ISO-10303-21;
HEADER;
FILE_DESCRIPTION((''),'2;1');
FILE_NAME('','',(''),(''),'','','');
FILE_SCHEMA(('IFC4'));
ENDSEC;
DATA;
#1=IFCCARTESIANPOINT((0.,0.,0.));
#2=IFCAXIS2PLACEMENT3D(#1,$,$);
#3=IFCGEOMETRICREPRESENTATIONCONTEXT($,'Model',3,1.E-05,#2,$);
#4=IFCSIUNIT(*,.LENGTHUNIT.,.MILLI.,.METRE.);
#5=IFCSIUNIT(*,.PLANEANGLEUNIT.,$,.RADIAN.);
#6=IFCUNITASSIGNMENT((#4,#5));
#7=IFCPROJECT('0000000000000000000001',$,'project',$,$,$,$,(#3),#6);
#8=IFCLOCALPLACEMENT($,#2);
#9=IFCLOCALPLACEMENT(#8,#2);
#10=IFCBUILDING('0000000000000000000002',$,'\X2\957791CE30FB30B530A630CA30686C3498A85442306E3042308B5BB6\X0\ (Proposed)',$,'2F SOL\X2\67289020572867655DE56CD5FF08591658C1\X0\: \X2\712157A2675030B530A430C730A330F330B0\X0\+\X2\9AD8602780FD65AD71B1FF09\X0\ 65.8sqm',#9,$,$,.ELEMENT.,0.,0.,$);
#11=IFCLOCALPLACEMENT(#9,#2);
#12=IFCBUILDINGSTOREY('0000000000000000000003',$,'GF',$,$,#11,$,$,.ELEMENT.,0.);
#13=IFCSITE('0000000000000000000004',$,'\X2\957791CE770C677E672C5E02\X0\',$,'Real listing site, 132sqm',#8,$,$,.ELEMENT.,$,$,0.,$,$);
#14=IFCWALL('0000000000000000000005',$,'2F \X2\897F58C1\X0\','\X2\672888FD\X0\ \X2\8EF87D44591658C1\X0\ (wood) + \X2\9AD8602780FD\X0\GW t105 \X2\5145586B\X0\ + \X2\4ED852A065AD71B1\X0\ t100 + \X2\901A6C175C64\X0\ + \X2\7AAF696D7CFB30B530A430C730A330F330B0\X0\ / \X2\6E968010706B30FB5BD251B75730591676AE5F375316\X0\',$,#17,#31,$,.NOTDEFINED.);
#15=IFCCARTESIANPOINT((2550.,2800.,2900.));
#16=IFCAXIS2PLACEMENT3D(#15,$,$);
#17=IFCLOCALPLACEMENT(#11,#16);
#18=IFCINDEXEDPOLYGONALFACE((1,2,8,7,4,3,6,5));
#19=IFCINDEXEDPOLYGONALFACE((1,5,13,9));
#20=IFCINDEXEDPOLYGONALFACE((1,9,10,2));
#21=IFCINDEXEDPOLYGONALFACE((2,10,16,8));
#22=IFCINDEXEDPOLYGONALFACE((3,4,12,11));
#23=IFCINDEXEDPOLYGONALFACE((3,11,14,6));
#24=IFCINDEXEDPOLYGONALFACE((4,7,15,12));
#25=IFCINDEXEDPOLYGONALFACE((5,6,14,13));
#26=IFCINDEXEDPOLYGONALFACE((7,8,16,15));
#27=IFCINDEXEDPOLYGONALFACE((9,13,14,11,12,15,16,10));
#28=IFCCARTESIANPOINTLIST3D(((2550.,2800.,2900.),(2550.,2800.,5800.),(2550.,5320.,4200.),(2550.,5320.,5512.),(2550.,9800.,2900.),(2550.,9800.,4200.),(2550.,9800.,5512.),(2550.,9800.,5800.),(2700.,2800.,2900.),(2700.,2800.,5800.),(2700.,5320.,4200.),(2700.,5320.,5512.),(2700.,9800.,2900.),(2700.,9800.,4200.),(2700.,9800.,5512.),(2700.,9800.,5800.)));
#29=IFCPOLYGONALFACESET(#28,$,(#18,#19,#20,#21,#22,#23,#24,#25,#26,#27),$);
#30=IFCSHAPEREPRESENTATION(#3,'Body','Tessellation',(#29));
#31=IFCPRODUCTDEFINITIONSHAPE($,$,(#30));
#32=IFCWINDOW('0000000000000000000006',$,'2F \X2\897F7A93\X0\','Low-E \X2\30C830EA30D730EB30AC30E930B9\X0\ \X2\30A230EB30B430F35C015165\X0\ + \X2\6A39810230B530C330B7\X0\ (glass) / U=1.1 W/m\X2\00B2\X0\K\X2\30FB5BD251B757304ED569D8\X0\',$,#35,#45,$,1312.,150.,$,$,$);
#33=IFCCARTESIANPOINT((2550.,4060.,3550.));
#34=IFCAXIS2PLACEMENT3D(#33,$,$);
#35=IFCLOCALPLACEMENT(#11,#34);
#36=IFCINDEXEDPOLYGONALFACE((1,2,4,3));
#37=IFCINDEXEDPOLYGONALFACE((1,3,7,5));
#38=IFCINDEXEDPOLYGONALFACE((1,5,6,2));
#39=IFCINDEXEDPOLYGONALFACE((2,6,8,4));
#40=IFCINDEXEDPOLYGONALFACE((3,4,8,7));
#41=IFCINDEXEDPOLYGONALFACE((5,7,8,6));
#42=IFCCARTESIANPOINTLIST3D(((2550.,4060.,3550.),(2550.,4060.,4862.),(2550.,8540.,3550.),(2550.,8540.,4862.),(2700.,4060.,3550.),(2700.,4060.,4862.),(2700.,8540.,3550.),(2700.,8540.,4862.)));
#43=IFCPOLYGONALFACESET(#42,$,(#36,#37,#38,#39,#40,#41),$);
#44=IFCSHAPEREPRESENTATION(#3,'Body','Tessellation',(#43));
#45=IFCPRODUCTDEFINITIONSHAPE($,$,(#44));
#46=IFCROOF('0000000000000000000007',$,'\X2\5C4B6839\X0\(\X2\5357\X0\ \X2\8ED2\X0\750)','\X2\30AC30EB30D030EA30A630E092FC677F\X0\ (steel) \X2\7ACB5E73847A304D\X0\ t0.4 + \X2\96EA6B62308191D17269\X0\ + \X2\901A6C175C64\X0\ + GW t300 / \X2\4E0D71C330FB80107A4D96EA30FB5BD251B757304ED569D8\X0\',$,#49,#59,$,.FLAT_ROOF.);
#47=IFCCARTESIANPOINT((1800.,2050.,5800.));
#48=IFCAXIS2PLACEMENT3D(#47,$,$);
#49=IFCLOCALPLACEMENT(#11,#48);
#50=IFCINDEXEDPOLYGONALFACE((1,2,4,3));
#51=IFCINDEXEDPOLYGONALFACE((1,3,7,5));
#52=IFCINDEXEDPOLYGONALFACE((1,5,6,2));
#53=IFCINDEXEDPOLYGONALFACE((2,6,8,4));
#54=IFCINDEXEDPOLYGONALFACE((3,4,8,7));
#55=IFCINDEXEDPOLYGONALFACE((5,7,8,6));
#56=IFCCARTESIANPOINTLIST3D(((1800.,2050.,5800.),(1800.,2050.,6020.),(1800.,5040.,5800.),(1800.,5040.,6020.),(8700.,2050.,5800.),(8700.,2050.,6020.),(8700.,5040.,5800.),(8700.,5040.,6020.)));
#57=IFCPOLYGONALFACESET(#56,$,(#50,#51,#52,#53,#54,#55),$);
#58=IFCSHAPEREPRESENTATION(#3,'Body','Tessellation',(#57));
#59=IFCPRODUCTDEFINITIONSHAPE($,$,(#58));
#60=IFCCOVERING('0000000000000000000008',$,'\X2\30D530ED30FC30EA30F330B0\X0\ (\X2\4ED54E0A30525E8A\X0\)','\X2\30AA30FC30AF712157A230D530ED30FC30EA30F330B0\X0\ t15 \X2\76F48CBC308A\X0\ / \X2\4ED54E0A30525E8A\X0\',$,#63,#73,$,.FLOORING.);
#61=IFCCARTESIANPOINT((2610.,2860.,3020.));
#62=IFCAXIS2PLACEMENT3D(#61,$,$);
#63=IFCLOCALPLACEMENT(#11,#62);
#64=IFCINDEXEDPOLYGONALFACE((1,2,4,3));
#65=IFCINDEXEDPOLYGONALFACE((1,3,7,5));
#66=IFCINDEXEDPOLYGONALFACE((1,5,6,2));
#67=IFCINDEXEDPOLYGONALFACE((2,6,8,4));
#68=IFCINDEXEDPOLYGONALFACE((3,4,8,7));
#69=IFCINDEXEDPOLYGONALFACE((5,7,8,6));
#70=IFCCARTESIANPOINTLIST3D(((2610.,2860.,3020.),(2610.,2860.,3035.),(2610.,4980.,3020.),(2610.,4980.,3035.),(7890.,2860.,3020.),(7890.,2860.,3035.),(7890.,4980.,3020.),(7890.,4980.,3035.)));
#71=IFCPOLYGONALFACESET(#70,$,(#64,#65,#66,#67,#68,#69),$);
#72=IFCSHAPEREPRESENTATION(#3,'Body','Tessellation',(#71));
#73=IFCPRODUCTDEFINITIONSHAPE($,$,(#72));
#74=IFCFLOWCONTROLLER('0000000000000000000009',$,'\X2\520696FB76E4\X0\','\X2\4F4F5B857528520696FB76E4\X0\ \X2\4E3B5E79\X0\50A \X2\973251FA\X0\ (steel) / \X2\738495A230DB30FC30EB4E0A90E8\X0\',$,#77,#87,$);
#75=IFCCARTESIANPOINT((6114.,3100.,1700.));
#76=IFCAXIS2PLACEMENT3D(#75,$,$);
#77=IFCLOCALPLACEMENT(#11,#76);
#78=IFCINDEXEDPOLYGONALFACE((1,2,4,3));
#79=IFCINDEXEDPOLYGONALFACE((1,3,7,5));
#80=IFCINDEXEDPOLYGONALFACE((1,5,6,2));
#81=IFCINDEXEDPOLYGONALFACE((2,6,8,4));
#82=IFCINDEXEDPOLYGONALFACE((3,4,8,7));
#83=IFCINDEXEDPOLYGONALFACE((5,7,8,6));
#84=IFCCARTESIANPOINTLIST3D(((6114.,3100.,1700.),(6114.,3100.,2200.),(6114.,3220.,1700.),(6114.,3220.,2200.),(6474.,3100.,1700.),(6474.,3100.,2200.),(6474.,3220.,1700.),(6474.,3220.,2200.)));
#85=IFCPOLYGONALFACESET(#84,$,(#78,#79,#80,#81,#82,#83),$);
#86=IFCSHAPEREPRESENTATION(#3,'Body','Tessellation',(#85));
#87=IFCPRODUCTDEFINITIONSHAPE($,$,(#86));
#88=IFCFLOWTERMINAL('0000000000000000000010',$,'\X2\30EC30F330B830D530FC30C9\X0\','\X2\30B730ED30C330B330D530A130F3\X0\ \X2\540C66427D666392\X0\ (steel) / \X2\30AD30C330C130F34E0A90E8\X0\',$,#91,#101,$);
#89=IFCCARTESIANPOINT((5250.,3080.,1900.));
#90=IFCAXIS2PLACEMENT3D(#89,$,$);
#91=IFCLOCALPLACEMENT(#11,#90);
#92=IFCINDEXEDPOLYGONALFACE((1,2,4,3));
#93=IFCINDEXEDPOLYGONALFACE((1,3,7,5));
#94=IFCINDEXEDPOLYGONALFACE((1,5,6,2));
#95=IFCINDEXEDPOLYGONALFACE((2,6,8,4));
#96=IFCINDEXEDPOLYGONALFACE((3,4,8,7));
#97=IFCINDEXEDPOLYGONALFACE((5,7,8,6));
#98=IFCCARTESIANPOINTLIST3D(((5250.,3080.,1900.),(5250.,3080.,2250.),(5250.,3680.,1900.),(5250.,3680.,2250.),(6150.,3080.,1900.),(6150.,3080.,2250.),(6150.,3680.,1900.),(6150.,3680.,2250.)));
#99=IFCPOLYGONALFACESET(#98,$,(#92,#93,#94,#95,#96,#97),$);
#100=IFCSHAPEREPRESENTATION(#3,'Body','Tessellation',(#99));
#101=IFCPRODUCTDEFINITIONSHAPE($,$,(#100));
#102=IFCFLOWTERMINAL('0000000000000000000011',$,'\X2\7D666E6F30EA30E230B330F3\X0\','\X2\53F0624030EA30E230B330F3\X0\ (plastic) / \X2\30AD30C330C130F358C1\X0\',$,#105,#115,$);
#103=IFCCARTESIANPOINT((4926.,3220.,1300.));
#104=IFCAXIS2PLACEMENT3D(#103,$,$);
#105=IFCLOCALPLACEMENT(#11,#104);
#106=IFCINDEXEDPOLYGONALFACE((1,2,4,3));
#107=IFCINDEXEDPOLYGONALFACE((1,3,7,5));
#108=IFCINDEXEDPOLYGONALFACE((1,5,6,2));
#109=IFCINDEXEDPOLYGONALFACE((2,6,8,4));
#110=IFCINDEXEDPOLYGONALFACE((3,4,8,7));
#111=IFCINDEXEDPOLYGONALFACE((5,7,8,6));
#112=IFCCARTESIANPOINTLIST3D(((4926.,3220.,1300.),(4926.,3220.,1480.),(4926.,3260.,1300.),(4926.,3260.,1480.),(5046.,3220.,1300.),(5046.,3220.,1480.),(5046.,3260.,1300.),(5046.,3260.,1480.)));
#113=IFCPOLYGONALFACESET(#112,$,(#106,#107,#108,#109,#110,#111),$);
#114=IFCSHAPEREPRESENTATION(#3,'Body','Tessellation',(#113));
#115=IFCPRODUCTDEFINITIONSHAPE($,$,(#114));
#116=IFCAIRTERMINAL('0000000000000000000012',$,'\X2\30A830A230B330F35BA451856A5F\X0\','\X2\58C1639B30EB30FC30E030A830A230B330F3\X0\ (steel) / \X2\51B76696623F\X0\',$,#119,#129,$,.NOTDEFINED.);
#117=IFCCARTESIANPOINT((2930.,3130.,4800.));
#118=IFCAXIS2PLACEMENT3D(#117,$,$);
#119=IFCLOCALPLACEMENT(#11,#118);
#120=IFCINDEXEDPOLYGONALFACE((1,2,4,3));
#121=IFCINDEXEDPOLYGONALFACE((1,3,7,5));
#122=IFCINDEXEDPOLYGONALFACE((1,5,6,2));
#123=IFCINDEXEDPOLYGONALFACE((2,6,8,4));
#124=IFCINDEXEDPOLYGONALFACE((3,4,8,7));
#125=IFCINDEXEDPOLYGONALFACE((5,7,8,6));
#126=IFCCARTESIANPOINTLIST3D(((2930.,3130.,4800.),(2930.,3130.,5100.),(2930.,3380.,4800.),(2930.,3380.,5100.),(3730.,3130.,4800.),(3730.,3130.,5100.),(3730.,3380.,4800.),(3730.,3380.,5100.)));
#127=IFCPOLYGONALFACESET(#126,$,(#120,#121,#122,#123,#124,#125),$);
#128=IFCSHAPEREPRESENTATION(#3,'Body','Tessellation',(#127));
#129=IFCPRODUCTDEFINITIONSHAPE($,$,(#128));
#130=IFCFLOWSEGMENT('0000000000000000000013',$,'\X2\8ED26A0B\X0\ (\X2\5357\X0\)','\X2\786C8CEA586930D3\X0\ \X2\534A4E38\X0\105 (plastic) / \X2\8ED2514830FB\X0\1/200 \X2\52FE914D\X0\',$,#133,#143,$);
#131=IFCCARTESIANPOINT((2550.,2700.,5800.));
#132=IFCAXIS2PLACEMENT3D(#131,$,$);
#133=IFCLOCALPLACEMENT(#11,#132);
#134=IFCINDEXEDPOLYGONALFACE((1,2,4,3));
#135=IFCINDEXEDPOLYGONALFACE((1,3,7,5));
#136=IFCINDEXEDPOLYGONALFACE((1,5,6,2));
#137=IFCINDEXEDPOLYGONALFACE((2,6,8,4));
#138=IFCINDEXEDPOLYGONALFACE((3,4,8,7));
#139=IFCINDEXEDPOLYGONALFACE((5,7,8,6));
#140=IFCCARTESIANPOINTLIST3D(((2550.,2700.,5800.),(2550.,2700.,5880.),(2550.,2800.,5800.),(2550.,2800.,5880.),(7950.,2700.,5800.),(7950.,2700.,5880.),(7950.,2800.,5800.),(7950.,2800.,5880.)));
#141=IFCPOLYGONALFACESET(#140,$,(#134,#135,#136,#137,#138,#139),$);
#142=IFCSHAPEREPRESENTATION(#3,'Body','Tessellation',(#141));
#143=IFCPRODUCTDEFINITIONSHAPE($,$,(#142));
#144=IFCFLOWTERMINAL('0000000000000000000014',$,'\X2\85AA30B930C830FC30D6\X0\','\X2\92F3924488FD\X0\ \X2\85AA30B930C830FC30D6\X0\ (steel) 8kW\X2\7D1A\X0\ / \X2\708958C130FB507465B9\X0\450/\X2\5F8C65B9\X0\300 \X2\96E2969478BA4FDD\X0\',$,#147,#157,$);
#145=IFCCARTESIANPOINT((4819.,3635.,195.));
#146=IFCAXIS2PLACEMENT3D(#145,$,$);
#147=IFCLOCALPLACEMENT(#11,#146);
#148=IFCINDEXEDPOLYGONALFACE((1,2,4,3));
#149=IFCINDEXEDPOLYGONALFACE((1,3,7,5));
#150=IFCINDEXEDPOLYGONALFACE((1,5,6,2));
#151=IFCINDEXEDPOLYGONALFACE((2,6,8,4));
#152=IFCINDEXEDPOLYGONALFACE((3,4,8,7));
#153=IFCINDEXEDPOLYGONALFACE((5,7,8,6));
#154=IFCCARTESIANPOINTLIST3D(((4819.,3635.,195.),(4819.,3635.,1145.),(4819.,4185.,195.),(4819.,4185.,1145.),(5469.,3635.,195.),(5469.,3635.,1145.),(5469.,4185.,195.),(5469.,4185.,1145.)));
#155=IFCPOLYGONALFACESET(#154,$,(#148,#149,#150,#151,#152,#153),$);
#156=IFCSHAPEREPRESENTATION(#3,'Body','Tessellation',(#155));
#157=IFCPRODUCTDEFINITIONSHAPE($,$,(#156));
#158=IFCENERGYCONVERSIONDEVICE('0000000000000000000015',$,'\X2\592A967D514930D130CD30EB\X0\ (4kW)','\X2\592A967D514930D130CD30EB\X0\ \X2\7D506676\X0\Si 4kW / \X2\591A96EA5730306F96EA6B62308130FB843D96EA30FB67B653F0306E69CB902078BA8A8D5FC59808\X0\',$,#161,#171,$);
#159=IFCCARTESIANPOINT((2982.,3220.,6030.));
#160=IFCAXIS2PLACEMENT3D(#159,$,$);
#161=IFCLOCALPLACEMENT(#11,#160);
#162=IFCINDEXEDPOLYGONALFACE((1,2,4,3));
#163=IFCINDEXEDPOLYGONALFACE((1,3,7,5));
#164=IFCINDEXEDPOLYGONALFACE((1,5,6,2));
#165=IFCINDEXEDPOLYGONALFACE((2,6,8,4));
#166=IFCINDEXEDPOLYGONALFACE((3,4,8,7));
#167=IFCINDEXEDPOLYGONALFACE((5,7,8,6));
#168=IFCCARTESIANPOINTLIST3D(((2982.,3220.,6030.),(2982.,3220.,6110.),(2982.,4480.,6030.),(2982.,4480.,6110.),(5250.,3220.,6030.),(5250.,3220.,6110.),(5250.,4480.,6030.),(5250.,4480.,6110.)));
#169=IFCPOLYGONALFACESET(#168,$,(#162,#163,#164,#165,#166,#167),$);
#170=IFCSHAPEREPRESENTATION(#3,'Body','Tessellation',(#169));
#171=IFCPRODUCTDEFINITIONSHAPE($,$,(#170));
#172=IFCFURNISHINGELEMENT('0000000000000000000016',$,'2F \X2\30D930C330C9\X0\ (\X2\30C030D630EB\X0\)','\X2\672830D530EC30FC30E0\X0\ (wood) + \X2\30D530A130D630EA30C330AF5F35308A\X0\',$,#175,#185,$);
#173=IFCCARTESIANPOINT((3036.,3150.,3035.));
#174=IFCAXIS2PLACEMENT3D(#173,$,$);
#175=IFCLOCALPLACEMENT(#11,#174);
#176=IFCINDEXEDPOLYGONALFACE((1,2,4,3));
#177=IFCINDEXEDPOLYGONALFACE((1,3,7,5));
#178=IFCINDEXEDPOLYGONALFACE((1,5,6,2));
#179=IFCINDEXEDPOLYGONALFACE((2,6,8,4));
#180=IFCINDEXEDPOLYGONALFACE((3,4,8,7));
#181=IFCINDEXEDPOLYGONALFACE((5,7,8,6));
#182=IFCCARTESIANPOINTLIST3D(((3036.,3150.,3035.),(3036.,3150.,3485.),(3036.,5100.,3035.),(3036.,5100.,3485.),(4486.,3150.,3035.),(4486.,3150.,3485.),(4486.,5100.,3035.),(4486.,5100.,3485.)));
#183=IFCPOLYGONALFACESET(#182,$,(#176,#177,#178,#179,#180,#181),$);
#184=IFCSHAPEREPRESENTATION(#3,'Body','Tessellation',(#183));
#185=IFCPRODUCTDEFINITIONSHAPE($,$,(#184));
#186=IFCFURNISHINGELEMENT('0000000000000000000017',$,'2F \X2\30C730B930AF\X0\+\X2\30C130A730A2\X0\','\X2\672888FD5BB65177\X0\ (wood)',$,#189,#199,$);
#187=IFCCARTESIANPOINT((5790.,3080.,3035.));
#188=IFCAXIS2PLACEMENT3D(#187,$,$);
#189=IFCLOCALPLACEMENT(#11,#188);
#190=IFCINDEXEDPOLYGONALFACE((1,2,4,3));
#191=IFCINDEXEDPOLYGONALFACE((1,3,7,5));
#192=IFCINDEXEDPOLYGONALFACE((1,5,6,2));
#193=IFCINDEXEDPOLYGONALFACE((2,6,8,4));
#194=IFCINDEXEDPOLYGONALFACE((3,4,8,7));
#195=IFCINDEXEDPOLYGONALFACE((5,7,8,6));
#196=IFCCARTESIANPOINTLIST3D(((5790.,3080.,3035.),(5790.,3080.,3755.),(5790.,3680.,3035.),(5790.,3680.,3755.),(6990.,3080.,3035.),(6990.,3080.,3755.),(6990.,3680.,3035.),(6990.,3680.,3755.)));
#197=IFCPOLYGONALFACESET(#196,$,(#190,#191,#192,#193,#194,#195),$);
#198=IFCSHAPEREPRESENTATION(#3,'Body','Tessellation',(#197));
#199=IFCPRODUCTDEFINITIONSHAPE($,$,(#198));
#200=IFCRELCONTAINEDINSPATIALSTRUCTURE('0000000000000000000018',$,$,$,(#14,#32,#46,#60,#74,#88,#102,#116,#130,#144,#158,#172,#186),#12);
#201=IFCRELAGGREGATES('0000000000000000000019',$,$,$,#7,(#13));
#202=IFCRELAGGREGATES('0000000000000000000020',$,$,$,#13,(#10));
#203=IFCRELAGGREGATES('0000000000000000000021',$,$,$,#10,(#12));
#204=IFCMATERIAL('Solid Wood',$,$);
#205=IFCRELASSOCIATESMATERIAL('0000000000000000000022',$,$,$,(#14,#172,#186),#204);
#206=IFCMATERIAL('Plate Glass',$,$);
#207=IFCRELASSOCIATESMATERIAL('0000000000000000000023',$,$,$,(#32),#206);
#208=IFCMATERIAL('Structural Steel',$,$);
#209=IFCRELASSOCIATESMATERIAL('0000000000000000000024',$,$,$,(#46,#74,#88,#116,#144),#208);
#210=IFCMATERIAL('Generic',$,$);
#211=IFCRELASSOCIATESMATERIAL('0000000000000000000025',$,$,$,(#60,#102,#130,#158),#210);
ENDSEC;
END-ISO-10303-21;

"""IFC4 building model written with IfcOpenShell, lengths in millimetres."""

from ifc_helpers import new_model, si_unit, frame, frame_2d, origin, place, context, project, spatial, rectangle, extrude, material, element, fill, save


model = new_model("IFC4")

# Units and contexts
model_context = context("Model", 3, precision=1e-05, world=origin())
ifc_project = project(units=[si_unit("LENGTHUNIT", "METRE", prefix="MILLI"), si_unit("PLANEANGLEUNIT", "RADIAN")], contexts=[model_context])

# Site, building, storey
site_placement = place(None, origin())
site = spatial("IfcSite", under=ifc_project, at=site_placement, Name="長野県松本市", ObjectType="Real listing site, 132sqm", CompositionType="ELEMENT", RefElevation=0.0)
building_placement = place(site_placement, origin())
building = spatial("IfcBuilding", under=site, at=building_placement, Name="長野・サウナと水風呂のある家 (Proposed)", ObjectType="2F SOL木造在来工法（外壁: 無垢材サイディング+高性能断熱） 65.8sqm", CompositionType="ELEMENT", ElevationOfRefHeight=0.0, ElevationOfTerrain=0.0)
storey_placement = place(building_placement, origin())
storey = spatial("IfcBuildingStorey", under=building, at=storey_placement, Name="GF", CompositionType="ELEMENT", Elevation=0.0)

# Shared definitions
ifc_material_1 = material(Name="Solid Wood")

# Wall, opening, window
ifc_material_2 = material(Name="Plate Glass")
wall_1_placement = place(storey_placement, frame((2550.0, 2800.0, 2900.0)))
wall_1 = element("IfcWall", 1, at=wall_1_placement, inside=storey, material=ifc_material_1, Name="2F 西壁", Description="木製 軸組外壁 (wood) + 高性能GW t105 充填 + 付加断熱 t100 + 通気層 + 窯業系サイディング / 準耐火・寒冷地外皮強化", PredefinedType="NOTDEFINED", context=model_context, shape_type="SweptSolid", body=[
    extrude(rectangle(XDim=150.0, YDim=7000.0, at=frame_2d((75.0, 3500.0))), frame((2550.0, 2800.0, 2900.0)), (0.0, 0.0, 1.0), 2900.0),
])
opening_1_placement = place(storey_placement, frame((2550.0, 4060.0, 3550.0)))
opening_1 = element("IfcOpeningElement", 2, at=opening_1_placement, cuts=wall_1, PredefinedType="NOTDEFINED", context=model_context, shape_type="SweptSolid", body=[
    extrude(rectangle(XDim=150.0, YDim=4480.0, at=frame_2d((75.0, 2240.0))), frame((2550.0, 4060.0, 3550.0)), (0.0, 0.0, 1.0), 1312.0),
])
window_1_placement = place(storey_placement, frame((2550.0, 4060.0, 3550.0)))
window_1 = element("IfcWindow", 3, at=window_1_placement, inside=storey, material=ifc_material_2, Name="2F 西窓", Description="Low-E トリプルガラス アルゴン封入 + 樹脂サッシ (glass) / U=1.1 W/m²K・寒冷地仕様", OverallHeight=1312.0, OverallWidth=150.0, context=model_context, shape_type="SweptSolid", body=[
    extrude(rectangle(XDim=150.0, YDim=4480.0, at=frame_2d((75.0, 2240.0))), frame((2550.0, 4060.0, 3550.0)), (0.0, 0.0, 1.0), 1312.0),
])
fill(opening_1, window_1)

# Roof
ifc_material_3 = material(Name="Structural Steel")
for number, where, name in (
    (4, (1800.0, 2050.0, 5800.0), "屋根(南 軒750)"),
):
    element("IfcRoof", number, at=place(storey_placement, frame(where)), inside=storey, material=ifc_material_3, Name=name, Description="ガルバリウム鋼板 (steel) 立平葺き t0.4 + 雪止め金物 + 通気層 + GW t300 / 不燃・耐積雪・寒冷地仕様", PredefinedType="FLAT_ROOF", context=model_context, shape_type="SweptSolid", body=[
        extrude(rectangle(XDim=6900.0, YDim=2990.0, at=frame_2d((3450.0, 1495.0))), frame((1800.0, 2050.0, 5800.0)), (0.0, 0.0, 1.0), 220.0),
    ])

# Covering
ifc_material_4 = material(Name="Generic")
covering_placement = place(storey_placement, frame((2610.0, 2860.0, 3020.0)))
element("IfcCovering", 5, at=covering_placement, inside=storey, material=ifc_material_4, Name="フローリング (仕上げ床)", Description="オーク無垢フローリング t15 直貼り / 仕上げ床", PredefinedType="FLOORING", context=model_context, shape_type="SweptSolid", body=[
    extrude(rectangle(XDim=5280.0, YDim=2120.0, at=frame_2d((2640.0, 1060.0))), frame((2610.0, 2860.0, 3020.0)), (0.0, 0.0, 1.0), 15.0),
])

# Flow controller
flow_controller_placement = place(storey_placement, frame((6114.0, 3100.0, 1700.0)))
element("IfcFlowController", 6, at=flow_controller_placement, inside=storey, material=ifc_material_3, Name="分電盤", Description="住宅用分電盤 主幹50A 露出 (steel) / 玄関ホール上部", context=model_context, shape_type="SweptSolid", body=[
    extrude(rectangle(XDim=360.0, YDim=120.0, at=frame_2d((180.0, 60.0))), frame((6114.0, 3100.0, 1700.0)), (0.0, 0.0, 1.0), 500.0),
])

# Flow terminals
flow_terminal_1_placement = place(storey_placement, frame((5250.0, 3080.0, 1900.0)))
element("IfcFlowTerminal", 7, at=flow_terminal_1_placement, inside=storey, material=ifc_material_3, Name="レンジフード", Description="シロッコファン 同時給排 (steel) / キッチン上部", context=model_context, shape_type="SweptSolid", body=[
    extrude(rectangle(XDim=900.0, YDim=600.0, at=frame_2d((450.0, 300.0))), frame((5250.0, 3080.0, 1900.0)), (0.0, 0.0, 1.0), 350.0),
])
flow_terminal_2_placement = place(storey_placement, frame((4926.0, 3220.0, 1300.0)))
element("IfcFlowTerminal", 8, at=flow_terminal_2_placement, inside=storey, material=ifc_material_4, Name="給湯リモコン", Description="台所リモコン (plastic) / キッチン壁", context=model_context, shape_type="SweptSolid", body=[
    extrude(rectangle(XDim=120.0, YDim=40.0, at=frame_2d((60.0, 20.0))), frame((4926.0, 3220.0, 1300.0)), (0.0, 0.0, 1.0), 180.0),
])

# Air terminal
air_terminal_placement = place(storey_placement, frame((2930.0, 3130.0, 4800.0)))
element("IfcAirTerminal", 9, at=air_terminal_placement, inside=storey, material=ifc_material_3, Name="エアコン室内機", Description="壁掛ルームエアコン (steel) / 冷暖房", PredefinedType="NOTDEFINED", context=model_context, shape_type="SweptSolid", body=[
    extrude(rectangle(XDim=800.0, YDim=250.0, at=frame_2d((400.0, 125.0))), frame((2930.0, 3130.0, 4800.0)), (0.0, 0.0, 1.0), 300.0),
])

# Flow segment
flow_segment_placement = place(storey_placement, frame((2550.0, 2700.0, 5800.0)))
element("IfcFlowSegment", 10, at=flow_segment_placement, inside=storey, material=ifc_material_4, Name="軒樋 (南)", Description="硬質塩ビ 半丸105 (plastic) / 軒先・1/200 勾配", context=model_context, shape_type="SweptSolid", body=[
    extrude(rectangle(XDim=5400.0, YDim=100.0, at=frame_2d((2700.0, 50.0))), frame((2550.0, 2700.0, 5800.0)), (0.0, 0.0, 1.0), 80.0),
])

# Flow terminal
flow_terminal_3_placement = place(storey_placement, frame((4819.0, 3635.0, 195.0)))
element("IfcFlowTerminal", 11, at=flow_terminal_3_placement, inside=storey, material=ifc_material_3, Name="薪ストーブ", Description="鋳鉄製 薪ストーブ (steel) 8kW級 / 炉壁・側方450/後方300 離隔確保", context=model_context, shape_type="SweptSolid", body=[
    extrude(rectangle(XDim=650.0, YDim=550.0, at=frame_2d((325.0, 275.0))), frame((4819.0, 3635.0, 195.0)), (0.0, 0.0, 1.0), 950.0),
])

# Energy conversion device
energy_conversion_device_placement = place(storey_placement, frame((2982.0, 3220.0, 6030.0)))
element("IfcEnergyConversionDevice", 12, at=energy_conversion_device_placement, inside=storey, material=ifc_material_4, Name="太陽光パネル (4kW)", Description="太陽光パネル 結晶Si 4kW / 多雪地は雪止め・落雪・架台の構造確認必須", context=model_context, shape_type="SweptSolid", body=[
    extrude(rectangle(XDim=2268.0, YDim=1260.0, at=frame_2d((1134.0, 630.0))), frame((2982.0, 3220.0, 6030.0)), (0.0, 0.0, 1.0), 80.0),
])

# Furnishing elements
furnishing_1_placement = place(storey_placement, frame((3036.0, 3150.0, 3035.0)))
element("IfcFurnishingElement", 13, at=furnishing_1_placement, inside=storey, material=ifc_material_1, Name="2F ベッド (ダブル)", Description="木フレーム (wood) + ファブリック張り", context=model_context, shape_type="SweptSolid", body=[
    extrude(rectangle(XDim=1450.0, YDim=1950.0, at=frame_2d((725.0, 975.0))), frame((3036.0, 3150.0, 3035.0)), (0.0, 0.0, 1.0), 450.0),
])
furnishing_2_placement = place(storey_placement, frame((5790.0, 3080.0, 3035.0)))
element("IfcFurnishingElement", 14, at=furnishing_2_placement, inside=storey, material=ifc_material_1, Name="2F デスク+チェア", Description="木製家具 (wood)", context=model_context, shape_type="SweptSolid", body=[
    extrude(rectangle(XDim=1200.0, YDim=600.0, at=frame_2d((600.0, 300.0))), frame((5790.0, 3080.0, 3035.0)), (0.0, 0.0, 1.0), 720.0),
])

save(model, "model.ifc")
